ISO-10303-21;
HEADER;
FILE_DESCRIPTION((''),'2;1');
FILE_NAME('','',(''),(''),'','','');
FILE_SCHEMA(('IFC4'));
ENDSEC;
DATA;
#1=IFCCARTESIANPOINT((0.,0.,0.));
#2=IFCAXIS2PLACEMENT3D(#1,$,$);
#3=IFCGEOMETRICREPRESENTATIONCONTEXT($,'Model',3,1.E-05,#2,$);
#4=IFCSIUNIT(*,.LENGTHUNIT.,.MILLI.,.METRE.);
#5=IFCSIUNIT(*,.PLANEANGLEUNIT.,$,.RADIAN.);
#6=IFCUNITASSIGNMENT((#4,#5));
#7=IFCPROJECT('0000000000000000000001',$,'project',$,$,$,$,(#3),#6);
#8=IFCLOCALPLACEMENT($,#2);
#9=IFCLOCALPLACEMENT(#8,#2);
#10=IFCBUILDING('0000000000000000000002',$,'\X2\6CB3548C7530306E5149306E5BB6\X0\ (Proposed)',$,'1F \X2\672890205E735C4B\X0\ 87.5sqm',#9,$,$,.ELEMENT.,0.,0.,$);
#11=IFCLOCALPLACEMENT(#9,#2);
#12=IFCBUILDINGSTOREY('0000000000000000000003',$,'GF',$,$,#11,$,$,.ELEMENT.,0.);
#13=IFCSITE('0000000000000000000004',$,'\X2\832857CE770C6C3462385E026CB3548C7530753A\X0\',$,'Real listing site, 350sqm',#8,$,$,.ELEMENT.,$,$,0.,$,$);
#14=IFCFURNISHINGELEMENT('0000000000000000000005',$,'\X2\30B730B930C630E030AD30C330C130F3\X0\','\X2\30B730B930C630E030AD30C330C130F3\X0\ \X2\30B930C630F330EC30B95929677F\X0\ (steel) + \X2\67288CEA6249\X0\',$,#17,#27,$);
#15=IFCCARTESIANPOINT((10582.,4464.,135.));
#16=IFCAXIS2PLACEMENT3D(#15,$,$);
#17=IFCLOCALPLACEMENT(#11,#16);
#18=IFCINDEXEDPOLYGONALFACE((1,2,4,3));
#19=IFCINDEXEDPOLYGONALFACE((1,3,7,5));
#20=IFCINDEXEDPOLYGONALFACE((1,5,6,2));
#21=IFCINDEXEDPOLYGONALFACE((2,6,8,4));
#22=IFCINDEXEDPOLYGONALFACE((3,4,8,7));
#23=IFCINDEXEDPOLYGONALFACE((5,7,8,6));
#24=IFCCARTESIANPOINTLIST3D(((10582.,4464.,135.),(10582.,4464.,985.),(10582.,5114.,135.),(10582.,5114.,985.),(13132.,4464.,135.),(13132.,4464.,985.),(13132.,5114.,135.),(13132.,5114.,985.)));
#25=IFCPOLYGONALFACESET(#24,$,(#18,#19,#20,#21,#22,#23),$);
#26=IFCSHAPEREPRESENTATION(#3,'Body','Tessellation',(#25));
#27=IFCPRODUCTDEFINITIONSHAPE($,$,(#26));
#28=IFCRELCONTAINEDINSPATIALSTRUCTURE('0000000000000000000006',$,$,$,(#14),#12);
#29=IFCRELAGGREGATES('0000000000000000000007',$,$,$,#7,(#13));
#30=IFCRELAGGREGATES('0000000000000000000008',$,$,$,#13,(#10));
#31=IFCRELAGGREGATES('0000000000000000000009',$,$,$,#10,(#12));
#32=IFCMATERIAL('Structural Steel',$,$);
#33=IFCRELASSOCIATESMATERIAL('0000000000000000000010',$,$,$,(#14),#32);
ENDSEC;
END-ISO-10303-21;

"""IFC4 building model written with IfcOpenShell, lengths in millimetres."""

from ifc_helpers import new_model, si_unit, frame, frame_2d, origin, place, context, project, spatial, rectangle, extrude, material, element, save


model = new_model("IFC4")

# Units and contexts
model_context = context("Model", 3, precision=1e-05, world=origin())
ifc_project = project(units=[si_unit("LENGTHUNIT", "METRE", prefix="MILLI"), si_unit("PLANEANGLEUNIT", "RADIAN")], contexts=[model_context])

# Site, building, storey
site_placement = place(None, origin())
site = spatial("IfcSite", under=ifc_project, at=site_placement, Name="茨城県水戸市河和田町", ObjectType="Real listing site, 350sqm", CompositionType="ELEMENT", RefElevation=0.0)
building_placement = place(site_placement, origin())
building = spatial("IfcBuilding", under=site, at=building_placement, Name="河和田の光の家 (Proposed)", ObjectType="1F 木造平屋 87.5sqm", CompositionType="ELEMENT", ElevationOfRefHeight=0.0, ElevationOfTerrain=0.0)
storey_placement = place(building_placement, origin())
storey = spatial("IfcBuildingStorey", under=building, at=storey_placement, Name="GF", CompositionType="ELEMENT", Elevation=0.0)

# Furnishing element
ifc_material_1 = material(Name="Structural Steel")
furnishing_1_placement = place(storey_placement, frame((10582.0, 4464.0, 135.0)))
element("IfcFurnishingElement", 1, at=furnishing_1_placement, inside=storey, material=ifc_material_1, Name="システムキッチン", Description="システムキッチン ステンレス天板 (steel) + 木質扉", context=model_context, shape_type="SweptSolid", body=[
    extrude(rectangle(XDim=2550.0, YDim=650.0, at=frame_2d((1275.0, 325.0))), frame((10582.0, 4464.0, 135.0)), (0.0, 0.0, 1.0), 850.0),
])

save(model, "model.ifc")
